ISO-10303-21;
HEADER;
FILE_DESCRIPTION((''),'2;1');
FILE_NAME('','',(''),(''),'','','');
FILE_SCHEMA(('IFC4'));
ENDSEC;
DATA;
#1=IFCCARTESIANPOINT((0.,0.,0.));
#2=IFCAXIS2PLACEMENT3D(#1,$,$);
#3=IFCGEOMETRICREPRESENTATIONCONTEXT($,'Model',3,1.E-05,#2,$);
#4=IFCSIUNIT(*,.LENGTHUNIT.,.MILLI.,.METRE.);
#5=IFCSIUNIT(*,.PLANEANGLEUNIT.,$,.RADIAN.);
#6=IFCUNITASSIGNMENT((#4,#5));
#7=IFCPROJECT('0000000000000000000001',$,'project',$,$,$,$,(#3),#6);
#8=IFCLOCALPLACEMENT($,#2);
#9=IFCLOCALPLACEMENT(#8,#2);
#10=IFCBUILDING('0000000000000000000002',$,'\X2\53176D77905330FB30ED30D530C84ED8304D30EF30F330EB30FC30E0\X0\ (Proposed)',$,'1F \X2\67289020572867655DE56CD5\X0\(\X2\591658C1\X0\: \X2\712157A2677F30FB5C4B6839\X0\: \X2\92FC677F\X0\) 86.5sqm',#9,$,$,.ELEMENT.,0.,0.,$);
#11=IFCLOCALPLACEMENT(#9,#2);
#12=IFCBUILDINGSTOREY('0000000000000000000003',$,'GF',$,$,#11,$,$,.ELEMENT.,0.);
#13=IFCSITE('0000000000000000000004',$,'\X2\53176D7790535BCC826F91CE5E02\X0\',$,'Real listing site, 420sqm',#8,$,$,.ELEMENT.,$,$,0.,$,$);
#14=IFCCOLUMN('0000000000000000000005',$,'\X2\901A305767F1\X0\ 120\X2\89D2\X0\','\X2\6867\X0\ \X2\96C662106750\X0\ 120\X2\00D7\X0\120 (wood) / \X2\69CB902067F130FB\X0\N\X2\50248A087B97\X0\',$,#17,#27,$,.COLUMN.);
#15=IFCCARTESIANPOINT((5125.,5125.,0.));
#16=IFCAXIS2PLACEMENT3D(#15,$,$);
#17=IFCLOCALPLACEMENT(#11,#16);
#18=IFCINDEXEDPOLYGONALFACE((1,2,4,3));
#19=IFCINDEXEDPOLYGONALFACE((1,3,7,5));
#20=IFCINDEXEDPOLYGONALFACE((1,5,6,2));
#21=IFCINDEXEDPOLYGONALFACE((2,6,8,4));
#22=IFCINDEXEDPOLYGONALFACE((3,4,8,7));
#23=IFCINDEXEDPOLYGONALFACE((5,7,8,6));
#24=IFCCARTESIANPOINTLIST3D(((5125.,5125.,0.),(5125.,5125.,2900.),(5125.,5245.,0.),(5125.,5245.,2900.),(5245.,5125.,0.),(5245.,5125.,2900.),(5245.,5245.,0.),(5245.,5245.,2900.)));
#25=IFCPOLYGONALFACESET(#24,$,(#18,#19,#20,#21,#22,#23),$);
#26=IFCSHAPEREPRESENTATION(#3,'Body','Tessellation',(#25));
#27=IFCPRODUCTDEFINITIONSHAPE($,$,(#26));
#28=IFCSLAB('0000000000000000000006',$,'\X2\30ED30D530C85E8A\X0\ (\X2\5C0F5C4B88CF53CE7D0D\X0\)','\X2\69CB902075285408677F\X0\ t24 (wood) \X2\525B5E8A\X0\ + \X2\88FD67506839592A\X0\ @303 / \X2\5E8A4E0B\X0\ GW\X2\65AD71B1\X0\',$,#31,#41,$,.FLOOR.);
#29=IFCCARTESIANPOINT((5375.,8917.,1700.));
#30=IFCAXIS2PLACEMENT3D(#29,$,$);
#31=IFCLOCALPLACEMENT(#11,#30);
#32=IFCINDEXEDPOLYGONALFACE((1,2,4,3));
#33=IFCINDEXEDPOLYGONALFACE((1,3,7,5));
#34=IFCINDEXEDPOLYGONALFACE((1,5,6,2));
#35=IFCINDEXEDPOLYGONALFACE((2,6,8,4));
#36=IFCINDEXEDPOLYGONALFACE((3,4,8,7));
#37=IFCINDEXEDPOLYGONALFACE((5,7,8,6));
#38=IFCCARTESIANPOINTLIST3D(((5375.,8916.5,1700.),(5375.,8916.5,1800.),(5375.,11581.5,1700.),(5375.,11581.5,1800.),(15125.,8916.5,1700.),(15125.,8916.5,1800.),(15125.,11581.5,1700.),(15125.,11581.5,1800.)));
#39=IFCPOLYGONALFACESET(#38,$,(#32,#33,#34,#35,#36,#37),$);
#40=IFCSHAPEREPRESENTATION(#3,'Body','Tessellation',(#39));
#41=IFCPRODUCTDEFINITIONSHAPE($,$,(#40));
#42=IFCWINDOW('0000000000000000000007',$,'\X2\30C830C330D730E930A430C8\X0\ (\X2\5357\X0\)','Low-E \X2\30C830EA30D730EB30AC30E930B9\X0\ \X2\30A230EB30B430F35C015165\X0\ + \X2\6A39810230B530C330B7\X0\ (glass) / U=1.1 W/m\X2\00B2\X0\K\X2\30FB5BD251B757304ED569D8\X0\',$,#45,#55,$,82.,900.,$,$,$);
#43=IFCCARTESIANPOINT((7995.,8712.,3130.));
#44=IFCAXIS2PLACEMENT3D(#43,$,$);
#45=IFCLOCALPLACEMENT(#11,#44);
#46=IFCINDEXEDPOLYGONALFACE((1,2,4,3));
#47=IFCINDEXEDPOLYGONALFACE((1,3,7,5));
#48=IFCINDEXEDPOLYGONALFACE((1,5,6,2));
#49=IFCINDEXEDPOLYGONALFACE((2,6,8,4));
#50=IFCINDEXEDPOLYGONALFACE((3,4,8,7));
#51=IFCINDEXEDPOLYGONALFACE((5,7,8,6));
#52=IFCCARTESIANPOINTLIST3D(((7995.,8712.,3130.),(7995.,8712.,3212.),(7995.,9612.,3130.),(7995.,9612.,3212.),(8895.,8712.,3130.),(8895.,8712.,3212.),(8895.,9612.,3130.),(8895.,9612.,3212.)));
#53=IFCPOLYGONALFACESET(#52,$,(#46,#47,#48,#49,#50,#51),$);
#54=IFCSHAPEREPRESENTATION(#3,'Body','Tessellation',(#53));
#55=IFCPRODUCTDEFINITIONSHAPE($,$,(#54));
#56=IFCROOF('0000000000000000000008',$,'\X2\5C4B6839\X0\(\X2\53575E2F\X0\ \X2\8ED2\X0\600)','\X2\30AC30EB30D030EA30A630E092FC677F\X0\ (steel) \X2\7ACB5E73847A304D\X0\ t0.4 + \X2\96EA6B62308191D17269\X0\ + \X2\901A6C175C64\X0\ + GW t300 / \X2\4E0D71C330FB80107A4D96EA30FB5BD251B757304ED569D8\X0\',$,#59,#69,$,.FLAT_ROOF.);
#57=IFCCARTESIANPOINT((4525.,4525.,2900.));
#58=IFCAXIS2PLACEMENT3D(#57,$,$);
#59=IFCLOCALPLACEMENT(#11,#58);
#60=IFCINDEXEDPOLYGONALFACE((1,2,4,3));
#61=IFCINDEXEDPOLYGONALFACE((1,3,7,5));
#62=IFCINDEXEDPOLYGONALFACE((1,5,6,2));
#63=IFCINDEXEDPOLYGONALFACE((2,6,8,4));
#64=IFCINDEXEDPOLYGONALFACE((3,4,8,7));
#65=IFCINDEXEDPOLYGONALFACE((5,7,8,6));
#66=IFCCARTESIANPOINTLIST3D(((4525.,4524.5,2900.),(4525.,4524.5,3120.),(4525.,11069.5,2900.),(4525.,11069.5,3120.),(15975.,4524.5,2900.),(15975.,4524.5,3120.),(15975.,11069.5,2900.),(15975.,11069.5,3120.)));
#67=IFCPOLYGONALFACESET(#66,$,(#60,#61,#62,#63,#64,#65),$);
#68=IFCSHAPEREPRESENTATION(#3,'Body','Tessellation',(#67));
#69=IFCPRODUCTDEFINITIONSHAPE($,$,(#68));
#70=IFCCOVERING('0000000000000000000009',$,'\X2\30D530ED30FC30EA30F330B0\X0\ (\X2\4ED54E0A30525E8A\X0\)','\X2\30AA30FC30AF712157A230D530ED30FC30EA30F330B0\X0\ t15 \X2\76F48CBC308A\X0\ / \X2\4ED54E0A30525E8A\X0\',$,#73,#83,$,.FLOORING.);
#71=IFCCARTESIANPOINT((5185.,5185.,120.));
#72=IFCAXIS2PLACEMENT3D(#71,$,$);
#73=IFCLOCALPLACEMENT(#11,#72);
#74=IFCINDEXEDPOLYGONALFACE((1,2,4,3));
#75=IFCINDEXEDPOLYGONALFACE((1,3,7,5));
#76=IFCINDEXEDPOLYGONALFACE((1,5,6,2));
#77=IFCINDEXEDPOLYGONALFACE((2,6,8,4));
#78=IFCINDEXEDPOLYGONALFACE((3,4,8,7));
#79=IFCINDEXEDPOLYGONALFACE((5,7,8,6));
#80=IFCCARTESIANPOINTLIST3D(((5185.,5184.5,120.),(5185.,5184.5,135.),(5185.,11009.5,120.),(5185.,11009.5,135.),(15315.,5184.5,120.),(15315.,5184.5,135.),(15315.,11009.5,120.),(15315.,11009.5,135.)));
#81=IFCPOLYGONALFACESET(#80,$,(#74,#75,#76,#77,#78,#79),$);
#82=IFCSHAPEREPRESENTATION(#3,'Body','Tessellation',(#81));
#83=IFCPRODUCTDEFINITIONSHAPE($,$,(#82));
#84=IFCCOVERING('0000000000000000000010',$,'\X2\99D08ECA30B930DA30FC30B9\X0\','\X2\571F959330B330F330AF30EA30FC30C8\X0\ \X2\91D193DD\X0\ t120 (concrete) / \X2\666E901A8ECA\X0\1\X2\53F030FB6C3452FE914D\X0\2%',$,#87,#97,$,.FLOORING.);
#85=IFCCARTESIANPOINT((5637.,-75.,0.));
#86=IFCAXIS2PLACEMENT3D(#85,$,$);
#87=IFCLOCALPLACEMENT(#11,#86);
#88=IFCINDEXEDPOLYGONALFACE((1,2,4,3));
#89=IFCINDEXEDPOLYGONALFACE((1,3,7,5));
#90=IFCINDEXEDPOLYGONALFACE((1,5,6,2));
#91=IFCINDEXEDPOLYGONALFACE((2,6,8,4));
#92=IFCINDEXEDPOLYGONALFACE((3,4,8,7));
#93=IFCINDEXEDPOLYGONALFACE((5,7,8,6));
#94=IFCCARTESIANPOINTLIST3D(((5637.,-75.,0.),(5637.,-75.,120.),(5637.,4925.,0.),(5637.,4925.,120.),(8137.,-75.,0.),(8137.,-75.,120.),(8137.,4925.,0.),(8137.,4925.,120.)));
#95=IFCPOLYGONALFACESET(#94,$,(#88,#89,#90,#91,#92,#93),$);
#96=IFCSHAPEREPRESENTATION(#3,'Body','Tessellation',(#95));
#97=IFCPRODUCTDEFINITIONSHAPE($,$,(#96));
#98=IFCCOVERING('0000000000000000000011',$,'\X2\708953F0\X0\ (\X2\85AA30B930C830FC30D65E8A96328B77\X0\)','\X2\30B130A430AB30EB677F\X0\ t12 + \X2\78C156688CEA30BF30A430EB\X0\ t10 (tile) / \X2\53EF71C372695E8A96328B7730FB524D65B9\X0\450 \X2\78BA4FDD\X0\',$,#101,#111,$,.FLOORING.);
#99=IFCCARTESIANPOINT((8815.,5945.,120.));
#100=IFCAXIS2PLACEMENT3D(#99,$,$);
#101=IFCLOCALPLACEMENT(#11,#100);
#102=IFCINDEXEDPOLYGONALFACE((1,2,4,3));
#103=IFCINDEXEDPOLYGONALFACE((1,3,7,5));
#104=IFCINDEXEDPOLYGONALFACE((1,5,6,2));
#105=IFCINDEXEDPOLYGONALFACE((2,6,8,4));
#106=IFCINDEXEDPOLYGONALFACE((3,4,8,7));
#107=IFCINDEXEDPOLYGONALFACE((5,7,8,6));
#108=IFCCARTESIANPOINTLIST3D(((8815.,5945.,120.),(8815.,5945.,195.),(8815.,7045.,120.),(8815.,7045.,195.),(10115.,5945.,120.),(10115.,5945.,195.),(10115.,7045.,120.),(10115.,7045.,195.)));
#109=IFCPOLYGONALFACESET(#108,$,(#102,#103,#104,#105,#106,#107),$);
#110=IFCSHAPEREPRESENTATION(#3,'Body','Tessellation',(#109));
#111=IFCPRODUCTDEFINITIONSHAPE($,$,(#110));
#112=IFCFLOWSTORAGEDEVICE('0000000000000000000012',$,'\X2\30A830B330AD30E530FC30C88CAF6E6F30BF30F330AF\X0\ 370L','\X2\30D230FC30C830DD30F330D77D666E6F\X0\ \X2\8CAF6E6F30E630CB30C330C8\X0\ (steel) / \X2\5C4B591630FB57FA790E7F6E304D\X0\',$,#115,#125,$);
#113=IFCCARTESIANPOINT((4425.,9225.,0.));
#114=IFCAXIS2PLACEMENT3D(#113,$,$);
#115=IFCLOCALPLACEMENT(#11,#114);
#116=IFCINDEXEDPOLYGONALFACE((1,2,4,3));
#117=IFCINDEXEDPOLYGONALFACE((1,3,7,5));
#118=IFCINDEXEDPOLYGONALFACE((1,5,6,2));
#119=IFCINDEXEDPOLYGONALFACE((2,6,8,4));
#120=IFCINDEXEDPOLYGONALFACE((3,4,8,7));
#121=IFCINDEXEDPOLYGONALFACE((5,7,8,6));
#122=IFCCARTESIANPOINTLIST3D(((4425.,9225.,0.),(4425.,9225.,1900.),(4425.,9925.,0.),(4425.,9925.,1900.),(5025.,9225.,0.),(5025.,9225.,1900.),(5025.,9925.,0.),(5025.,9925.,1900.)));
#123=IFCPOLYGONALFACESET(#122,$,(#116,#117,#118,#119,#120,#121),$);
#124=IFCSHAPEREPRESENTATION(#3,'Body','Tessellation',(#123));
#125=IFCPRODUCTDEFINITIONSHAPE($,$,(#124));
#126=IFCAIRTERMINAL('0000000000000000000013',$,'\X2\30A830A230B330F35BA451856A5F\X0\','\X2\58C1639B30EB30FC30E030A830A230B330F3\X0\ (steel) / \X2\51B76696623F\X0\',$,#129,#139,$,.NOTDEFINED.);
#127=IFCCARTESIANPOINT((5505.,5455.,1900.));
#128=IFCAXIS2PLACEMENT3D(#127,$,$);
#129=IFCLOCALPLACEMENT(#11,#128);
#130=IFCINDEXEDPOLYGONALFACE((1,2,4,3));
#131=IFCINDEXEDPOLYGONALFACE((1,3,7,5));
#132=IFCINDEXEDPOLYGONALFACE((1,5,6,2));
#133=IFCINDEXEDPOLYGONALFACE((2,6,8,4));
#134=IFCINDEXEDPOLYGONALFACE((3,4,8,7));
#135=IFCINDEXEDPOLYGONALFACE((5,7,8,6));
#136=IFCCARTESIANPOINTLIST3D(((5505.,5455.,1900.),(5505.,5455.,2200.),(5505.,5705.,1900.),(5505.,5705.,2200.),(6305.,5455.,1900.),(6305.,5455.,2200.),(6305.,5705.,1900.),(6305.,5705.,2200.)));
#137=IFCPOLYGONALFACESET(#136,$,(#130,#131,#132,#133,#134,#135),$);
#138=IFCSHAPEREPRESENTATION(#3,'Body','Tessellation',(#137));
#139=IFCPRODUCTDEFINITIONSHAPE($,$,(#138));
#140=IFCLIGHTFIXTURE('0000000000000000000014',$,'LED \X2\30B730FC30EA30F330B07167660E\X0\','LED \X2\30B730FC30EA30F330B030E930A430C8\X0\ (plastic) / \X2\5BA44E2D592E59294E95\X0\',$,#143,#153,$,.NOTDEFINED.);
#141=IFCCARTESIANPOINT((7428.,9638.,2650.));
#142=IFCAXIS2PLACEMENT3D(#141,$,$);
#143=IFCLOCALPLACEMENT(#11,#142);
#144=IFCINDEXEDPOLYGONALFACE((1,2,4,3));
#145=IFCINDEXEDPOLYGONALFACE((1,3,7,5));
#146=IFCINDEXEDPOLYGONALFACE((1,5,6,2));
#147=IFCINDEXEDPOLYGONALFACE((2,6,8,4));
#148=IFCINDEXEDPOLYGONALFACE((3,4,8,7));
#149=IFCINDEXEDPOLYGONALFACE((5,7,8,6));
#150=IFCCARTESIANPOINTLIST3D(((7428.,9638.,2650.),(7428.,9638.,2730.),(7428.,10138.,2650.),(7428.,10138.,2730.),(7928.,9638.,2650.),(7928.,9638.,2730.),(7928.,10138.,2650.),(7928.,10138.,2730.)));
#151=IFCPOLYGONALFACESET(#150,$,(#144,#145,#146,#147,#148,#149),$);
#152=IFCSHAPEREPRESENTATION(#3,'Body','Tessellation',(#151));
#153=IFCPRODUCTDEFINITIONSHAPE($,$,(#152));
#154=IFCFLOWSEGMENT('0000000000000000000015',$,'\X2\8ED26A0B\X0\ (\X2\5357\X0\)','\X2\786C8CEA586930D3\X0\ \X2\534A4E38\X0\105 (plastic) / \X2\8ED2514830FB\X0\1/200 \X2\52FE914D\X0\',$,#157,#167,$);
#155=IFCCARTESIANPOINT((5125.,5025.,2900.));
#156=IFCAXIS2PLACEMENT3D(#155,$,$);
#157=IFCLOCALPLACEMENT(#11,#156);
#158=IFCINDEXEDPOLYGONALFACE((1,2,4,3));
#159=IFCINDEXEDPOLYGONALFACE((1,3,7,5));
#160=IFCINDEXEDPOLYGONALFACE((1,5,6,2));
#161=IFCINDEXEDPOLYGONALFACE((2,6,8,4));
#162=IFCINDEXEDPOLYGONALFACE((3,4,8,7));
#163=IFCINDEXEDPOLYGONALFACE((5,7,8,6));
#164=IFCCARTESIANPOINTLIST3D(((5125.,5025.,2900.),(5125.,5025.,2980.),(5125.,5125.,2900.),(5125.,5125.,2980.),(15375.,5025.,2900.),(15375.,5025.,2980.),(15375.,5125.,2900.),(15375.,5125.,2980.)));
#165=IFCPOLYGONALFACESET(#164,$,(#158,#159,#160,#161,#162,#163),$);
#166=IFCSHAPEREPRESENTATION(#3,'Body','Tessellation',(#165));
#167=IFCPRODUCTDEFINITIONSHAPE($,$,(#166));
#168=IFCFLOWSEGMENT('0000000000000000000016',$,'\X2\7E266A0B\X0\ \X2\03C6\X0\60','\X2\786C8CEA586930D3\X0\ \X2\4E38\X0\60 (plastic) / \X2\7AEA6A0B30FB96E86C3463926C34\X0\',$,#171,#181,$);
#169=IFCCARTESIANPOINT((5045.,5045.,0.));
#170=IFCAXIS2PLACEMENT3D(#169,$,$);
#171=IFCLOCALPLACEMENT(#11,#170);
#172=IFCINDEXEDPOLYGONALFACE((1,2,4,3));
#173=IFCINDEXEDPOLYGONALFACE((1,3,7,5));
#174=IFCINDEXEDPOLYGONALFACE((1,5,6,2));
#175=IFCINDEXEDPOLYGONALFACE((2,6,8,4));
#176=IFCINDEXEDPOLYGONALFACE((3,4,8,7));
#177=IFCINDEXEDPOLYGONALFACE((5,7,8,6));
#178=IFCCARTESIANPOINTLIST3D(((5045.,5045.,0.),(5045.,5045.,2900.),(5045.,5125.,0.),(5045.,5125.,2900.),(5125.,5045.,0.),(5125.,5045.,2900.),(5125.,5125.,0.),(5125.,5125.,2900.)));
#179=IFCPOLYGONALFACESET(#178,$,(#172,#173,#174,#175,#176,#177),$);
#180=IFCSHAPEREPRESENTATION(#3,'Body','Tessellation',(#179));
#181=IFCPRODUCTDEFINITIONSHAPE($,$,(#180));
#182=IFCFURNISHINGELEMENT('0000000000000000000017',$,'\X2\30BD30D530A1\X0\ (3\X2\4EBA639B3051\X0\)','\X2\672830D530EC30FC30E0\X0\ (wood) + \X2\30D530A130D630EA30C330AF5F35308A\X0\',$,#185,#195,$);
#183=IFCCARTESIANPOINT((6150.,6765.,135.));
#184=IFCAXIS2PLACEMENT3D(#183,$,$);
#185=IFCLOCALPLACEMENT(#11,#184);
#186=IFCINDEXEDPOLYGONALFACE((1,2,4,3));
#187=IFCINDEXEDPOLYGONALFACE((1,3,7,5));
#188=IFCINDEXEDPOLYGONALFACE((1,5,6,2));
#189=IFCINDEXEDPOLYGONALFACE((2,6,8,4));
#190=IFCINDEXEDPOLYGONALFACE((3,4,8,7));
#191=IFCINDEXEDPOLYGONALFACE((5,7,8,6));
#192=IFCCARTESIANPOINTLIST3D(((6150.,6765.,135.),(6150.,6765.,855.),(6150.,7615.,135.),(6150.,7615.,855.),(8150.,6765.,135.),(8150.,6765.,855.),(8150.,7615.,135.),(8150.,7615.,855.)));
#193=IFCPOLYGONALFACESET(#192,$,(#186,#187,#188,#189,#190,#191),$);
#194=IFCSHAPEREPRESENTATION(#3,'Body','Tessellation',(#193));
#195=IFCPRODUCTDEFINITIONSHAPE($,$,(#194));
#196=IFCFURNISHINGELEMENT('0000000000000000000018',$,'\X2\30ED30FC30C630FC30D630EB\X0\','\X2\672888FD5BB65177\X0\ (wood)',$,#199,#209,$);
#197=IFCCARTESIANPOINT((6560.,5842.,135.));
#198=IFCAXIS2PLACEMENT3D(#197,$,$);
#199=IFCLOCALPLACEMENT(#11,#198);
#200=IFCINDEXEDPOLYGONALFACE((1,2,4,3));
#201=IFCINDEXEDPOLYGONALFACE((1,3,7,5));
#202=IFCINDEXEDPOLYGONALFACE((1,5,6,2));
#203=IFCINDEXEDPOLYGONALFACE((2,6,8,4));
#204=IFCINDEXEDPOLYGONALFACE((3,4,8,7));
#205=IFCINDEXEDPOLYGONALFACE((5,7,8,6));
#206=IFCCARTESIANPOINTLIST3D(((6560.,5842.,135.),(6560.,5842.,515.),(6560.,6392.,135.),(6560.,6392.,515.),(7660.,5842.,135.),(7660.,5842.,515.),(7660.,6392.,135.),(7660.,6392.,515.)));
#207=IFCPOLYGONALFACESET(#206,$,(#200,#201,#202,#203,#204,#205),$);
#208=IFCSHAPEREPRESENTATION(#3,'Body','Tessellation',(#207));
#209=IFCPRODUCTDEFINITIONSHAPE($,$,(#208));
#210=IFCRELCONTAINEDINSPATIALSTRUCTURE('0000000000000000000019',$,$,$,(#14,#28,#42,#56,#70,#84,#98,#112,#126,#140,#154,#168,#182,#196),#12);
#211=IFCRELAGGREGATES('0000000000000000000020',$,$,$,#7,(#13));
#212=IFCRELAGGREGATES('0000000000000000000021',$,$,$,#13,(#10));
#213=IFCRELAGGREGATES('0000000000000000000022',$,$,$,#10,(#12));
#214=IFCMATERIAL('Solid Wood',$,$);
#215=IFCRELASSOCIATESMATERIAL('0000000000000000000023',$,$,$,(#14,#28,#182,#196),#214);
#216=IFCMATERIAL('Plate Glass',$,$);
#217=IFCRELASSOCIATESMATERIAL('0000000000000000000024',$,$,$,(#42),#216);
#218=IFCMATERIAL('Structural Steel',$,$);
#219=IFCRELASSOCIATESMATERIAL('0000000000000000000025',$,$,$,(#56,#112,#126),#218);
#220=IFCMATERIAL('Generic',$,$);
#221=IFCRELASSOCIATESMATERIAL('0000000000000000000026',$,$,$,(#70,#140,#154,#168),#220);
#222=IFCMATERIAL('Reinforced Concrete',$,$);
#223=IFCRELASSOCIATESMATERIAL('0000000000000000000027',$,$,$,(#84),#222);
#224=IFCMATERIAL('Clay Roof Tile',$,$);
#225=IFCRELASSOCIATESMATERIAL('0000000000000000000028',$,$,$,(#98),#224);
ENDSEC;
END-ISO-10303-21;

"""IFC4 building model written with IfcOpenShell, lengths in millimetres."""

from ifc_helpers import new_model, si_unit, frame, frame_2d, origin, place, context, project, spatial, rectangle, extrude, material, element, save


model = new_model("IFC4")

# Units and contexts
model_context = context("Model", 3, precision=1e-05, world=origin())
ifc_project = project(units=[si_unit("LENGTHUNIT", "METRE", prefix="MILLI"), si_unit("PLANEANGLEUNIT", "RADIAN")], contexts=[model_context])

# Site, building, storey
site_placement = place(None, origin())
site = spatial("IfcSite", under=ifc_project, at=site_placement, Name="北海道富良野市", ObjectType="Real listing site, 420sqm", CompositionType="ELEMENT", RefElevation=0.0)
building_placement = place(site_placement, origin())
building = spatial("IfcBuilding", under=site, at=building_placement, Name="北海道・ロフト付きワンルーム (Proposed)", ObjectType="1F 木造在来工法(外壁: 無垢板・屋根: 鋼板) 86.5sqm", CompositionType="ELEMENT", ElevationOfRefHeight=0.0, ElevationOfTerrain=0.0)
storey_placement = place(building_placement, origin())
storey = spatial("IfcBuildingStorey", under=building, at=storey_placement, Name="GF", CompositionType="ELEMENT", Elevation=0.0)

# Column
ifc_material_1 = material(Name="Solid Wood")
column_1_placement = place(storey_placement, frame((5125.0, 5125.0, 0.0)))
element("IfcColumn", 1, at=column_1_placement, inside=storey, material=ifc_material_1, Name="通し柱 120角", Description="桧 集成材 120×120 (wood) / 構造柱・N値計算", PredefinedType="COLUMN", context=model_context, shape_type="SweptSolid", body=[
    extrude(rectangle(XDim=120.0, YDim=120.0, at=frame_2d((60.0, 60.0))), frame((5125.0, 5125.0, 0.0)), (0.0, 0.0, 1.0), 2900.0),
])

# Slab
ifc_material_2 = material(Name="Reinforced Concrete")
slab_1_placement = place(storey_placement, frame((5375.0, 8917.0, 1700.0)))
element("IfcSlab", 2, at=slab_1_placement, inside=storey, material=ifc_material_1, Name="ロフト床 (小屋裏収納)", Description="構造用合板 t24 (wood) 剛床 + 製材根太 @303 / 床下 GW断熱", PredefinedType="FLOOR", context=model_context, shape_type="SweptSolid", body=[
    extrude(rectangle(XDim=9750.0, YDim=2665.0, at=frame_2d((4875.0, 1332.0))), frame((5375.0, 8917.0, 1700.0)), (0.0, 0.0, 1.0), 100.0),
])

# Shared definitions
ifc_material_3 = material(Name="Plate Glass")

# Window
window_1_placement = place(storey_placement, frame((7995.0, 8712.0, 3130.0)))
element("IfcWindow", 3, at=window_1_placement, inside=storey, material=ifc_material_3, Name="トップライト (南)", Description="Low-E トリプルガラス アルゴン封入 + 樹脂サッシ (glass) / U=1.1 W/m²K・寒冷地仕様", OverallHeight=82.0, OverallWidth=900.0, context=model_context, shape_type="SweptSolid", body=[
    extrude(rectangle(XDim=900.0, YDim=900.0, at=frame_2d((450.0, 450.0))), frame((7995.0, 8712.0, 3130.0)), (0.0, 0.0, 1.0), 82.0),
])

# Roof
ifc_material_4 = material(Name="Structural Steel")
roof_placement = place(storey_placement, frame((4525.0, 4525.0, 2900.0)))
element("IfcRoof", 4, at=roof_placement, inside=storey, material=ifc_material_4, Name="屋根(南帯 軒600)", Description="ガルバリウム鋼板 (steel) 立平葺き t0.4 + 雪止め金物 + 通気層 + GW t300 / 不燃・耐積雪・寒冷地仕様", PredefinedType="FLAT_ROOF", context=model_context, shape_type="SweptSolid", body=[
    extrude(rectangle(XDim=11450.0, YDim=6545.0, at=frame_2d((5725.0, 3272.0))), frame((4525.0, 4525.0, 2900.0)), (0.0, 0.0, 1.0), 220.0),
])

# Coverings
ifc_material_5 = material(Name="Generic")
covering_1_placement = place(storey_placement, frame((5185.0, 5185.0, 120.0)))
element("IfcCovering", 5, at=covering_1_placement, inside=storey, material=ifc_material_5, Name="フローリング (仕上げ床)", Description="オーク無垢フローリング t15 直貼り / 仕上げ床", PredefinedType="FLOORING", context=model_context, shape_type="SweptSolid", body=[
    extrude(rectangle(XDim=10130.0, YDim=5825.0, at=frame_2d((5065.0, 2912.0))), frame((5185.0, 5185.0, 120.0)), (0.0, 0.0, 1.0), 15.0),
])
covering_2_placement = place(storey_placement, frame((5637.0, -75.0, 0.0)))
element("IfcCovering", 6, at=covering_2_placement, inside=storey, material=ifc_material_2, Name="駐車スペース", Description="土間コンクリート 金鏝 t120 (concrete) / 普通車1台・水勾配2%", PredefinedType="FLOORING", context=model_context, shape_type="SweptSolid", body=[
    extrude(rectangle(XDim=2500.0, YDim=5000.0, at=frame_2d((1250.0, 2500.0))), frame((5637.0, -75.0, 0.0)), (0.0, 0.0, 1.0), 120.0),
])
ifc_material_6 = material(Name="Clay Roof Tile")
covering_3_placement = place(storey_placement, frame((8815.0, 5945.0, 120.0)))
element("IfcCovering", 7, at=covering_3_placement, inside=storey, material=ifc_material_6, Name="炉台 (薪ストーブ床防護)", Description="ケイカル板 t12 + 磁器質タイル t10 (tile) / 可燃物床防護・前方450 確保", PredefinedType="FLOORING", context=model_context, shape_type="SweptSolid", body=[
    extrude(rectangle(XDim=1300.0, YDim=1100.0, at=frame_2d((650.0, 550.0))), frame((8815.0, 5945.0, 120.0)), (0.0, 0.0, 1.0), 75.0),
])

# Flow storage device
flow_storage_device_placement = place(storey_placement, frame((4425.0, 9225.0, 0.0)))
element("IfcFlowStorageDevice", 8, at=flow_storage_device_placement, inside=storey, material=ifc_material_4, Name="エコキュート貯湯タンク 370L", Description="ヒートポンプ給湯 貯湯ユニット (steel) / 屋外・基礎置き", context=model_context, shape_type="SweptSolid", body=[
    extrude(rectangle(XDim=600.0, YDim=700.0, at=frame_2d((300.0, 350.0))), frame((4425.0, 9225.0, 0.0)), (0.0, 0.0, 1.0), 1900.0),
])

# Air terminal
air_terminal_placement = place(storey_placement, frame((5505.0, 5455.0, 1900.0)))
element("IfcAirTerminal", 9, at=air_terminal_placement, inside=storey, material=ifc_material_4, Name="エアコン室内機", Description="壁掛ルームエアコン (steel) / 冷暖房", PredefinedType="NOTDEFINED", context=model_context, shape_type="SweptSolid", body=[
    extrude(rectangle(XDim=800.0, YDim=250.0, at=frame_2d((400.0, 125.0))), frame((5505.0, 5455.0, 1900.0)), (0.0, 0.0, 1.0), 300.0),
])

# Light fixture
light_fixture_placement = place(storey_placement, frame((7428.0, 9638.0, 2650.0)))
element("IfcLightFixture", 10, at=light_fixture_placement, inside=storey, material=ifc_material_5, Name="LED シーリング照明", Description="LED シーリングライト (plastic) / 室中央天井", PredefinedType="NOTDEFINED", context=model_context, shape_type="SweptSolid", body=[
    extrude(rectangle(XDim=500.0, YDim=500.0, at=frame_2d((250.0, 250.0))), frame((7428.0, 9638.0, 2650.0)), (0.0, 0.0, 1.0), 80.0),
])

# Flow segments
flow_segment_1_placement = place(storey_placement, frame((5125.0, 5025.0, 2900.0)))
element("IfcFlowSegment", 11, at=flow_segment_1_placement, inside=storey, material=ifc_material_5, Name="軒樋 (南)", Description="硬質塩ビ 半丸105 (plastic) / 軒先・1/200 勾配", context=model_context, shape_type="SweptSolid", body=[
    extrude(rectangle(XDim=10250.0, YDim=100.0, at=frame_2d((5125.0, 50.0))), frame((5125.0, 5025.0, 2900.0)), (0.0, 0.0, 1.0), 80.0),
])
flow_segment_2_placement = place(storey_placement, frame((5045.0, 5045.0, 0.0)))
element("IfcFlowSegment", 12, at=flow_segment_2_placement, inside=storey, material=ifc_material_5, Name="縦樋 φ60", Description="硬質塩ビ 丸60 (plastic) / 竪樋・雨水排水", context=model_context, shape_type="SweptSolid", body=[
    extrude(rectangle(XDim=80.0, YDim=80.0, at=frame_2d((40.0, 40.0))), frame((5045.0, 5045.0, 0.0)), (0.0, 0.0, 1.0), 2900.0),
])

# Furnishing elements
furnishing_1_placement = place(storey_placement, frame((6150.0, 6765.0, 135.0)))
element("IfcFurnishingElement", 13, at=furnishing_1_placement, inside=storey, material=ifc_material_1, Name="ソファ (3人掛け)", Description="木フレーム (wood) + ファブリック張り", context=model_context, shape_type="SweptSolid", body=[
    extrude(rectangle(XDim=2000.0, YDim=850.0, at=frame_2d((1000.0, 425.0))), frame((6150.0, 6765.0, 135.0)), (0.0, 0.0, 1.0), 720.0),
])
furnishing_2_placement = place(storey_placement, frame((6560.0, 5842.0, 135.0)))
element("IfcFurnishingElement", 14, at=furnishing_2_placement, inside=storey, material=ifc_material_1, Name="ローテーブル", Description="木製家具 (wood)", context=model_context, shape_type="SweptSolid", body=[
    extrude(rectangle(XDim=1100.0, YDim=550.0, at=frame_2d((550.0, 275.0))), frame((6560.0, 5842.0, 135.0)), (0.0, 0.0, 1.0), 380.0),
])

save(model, "model.ifc")
